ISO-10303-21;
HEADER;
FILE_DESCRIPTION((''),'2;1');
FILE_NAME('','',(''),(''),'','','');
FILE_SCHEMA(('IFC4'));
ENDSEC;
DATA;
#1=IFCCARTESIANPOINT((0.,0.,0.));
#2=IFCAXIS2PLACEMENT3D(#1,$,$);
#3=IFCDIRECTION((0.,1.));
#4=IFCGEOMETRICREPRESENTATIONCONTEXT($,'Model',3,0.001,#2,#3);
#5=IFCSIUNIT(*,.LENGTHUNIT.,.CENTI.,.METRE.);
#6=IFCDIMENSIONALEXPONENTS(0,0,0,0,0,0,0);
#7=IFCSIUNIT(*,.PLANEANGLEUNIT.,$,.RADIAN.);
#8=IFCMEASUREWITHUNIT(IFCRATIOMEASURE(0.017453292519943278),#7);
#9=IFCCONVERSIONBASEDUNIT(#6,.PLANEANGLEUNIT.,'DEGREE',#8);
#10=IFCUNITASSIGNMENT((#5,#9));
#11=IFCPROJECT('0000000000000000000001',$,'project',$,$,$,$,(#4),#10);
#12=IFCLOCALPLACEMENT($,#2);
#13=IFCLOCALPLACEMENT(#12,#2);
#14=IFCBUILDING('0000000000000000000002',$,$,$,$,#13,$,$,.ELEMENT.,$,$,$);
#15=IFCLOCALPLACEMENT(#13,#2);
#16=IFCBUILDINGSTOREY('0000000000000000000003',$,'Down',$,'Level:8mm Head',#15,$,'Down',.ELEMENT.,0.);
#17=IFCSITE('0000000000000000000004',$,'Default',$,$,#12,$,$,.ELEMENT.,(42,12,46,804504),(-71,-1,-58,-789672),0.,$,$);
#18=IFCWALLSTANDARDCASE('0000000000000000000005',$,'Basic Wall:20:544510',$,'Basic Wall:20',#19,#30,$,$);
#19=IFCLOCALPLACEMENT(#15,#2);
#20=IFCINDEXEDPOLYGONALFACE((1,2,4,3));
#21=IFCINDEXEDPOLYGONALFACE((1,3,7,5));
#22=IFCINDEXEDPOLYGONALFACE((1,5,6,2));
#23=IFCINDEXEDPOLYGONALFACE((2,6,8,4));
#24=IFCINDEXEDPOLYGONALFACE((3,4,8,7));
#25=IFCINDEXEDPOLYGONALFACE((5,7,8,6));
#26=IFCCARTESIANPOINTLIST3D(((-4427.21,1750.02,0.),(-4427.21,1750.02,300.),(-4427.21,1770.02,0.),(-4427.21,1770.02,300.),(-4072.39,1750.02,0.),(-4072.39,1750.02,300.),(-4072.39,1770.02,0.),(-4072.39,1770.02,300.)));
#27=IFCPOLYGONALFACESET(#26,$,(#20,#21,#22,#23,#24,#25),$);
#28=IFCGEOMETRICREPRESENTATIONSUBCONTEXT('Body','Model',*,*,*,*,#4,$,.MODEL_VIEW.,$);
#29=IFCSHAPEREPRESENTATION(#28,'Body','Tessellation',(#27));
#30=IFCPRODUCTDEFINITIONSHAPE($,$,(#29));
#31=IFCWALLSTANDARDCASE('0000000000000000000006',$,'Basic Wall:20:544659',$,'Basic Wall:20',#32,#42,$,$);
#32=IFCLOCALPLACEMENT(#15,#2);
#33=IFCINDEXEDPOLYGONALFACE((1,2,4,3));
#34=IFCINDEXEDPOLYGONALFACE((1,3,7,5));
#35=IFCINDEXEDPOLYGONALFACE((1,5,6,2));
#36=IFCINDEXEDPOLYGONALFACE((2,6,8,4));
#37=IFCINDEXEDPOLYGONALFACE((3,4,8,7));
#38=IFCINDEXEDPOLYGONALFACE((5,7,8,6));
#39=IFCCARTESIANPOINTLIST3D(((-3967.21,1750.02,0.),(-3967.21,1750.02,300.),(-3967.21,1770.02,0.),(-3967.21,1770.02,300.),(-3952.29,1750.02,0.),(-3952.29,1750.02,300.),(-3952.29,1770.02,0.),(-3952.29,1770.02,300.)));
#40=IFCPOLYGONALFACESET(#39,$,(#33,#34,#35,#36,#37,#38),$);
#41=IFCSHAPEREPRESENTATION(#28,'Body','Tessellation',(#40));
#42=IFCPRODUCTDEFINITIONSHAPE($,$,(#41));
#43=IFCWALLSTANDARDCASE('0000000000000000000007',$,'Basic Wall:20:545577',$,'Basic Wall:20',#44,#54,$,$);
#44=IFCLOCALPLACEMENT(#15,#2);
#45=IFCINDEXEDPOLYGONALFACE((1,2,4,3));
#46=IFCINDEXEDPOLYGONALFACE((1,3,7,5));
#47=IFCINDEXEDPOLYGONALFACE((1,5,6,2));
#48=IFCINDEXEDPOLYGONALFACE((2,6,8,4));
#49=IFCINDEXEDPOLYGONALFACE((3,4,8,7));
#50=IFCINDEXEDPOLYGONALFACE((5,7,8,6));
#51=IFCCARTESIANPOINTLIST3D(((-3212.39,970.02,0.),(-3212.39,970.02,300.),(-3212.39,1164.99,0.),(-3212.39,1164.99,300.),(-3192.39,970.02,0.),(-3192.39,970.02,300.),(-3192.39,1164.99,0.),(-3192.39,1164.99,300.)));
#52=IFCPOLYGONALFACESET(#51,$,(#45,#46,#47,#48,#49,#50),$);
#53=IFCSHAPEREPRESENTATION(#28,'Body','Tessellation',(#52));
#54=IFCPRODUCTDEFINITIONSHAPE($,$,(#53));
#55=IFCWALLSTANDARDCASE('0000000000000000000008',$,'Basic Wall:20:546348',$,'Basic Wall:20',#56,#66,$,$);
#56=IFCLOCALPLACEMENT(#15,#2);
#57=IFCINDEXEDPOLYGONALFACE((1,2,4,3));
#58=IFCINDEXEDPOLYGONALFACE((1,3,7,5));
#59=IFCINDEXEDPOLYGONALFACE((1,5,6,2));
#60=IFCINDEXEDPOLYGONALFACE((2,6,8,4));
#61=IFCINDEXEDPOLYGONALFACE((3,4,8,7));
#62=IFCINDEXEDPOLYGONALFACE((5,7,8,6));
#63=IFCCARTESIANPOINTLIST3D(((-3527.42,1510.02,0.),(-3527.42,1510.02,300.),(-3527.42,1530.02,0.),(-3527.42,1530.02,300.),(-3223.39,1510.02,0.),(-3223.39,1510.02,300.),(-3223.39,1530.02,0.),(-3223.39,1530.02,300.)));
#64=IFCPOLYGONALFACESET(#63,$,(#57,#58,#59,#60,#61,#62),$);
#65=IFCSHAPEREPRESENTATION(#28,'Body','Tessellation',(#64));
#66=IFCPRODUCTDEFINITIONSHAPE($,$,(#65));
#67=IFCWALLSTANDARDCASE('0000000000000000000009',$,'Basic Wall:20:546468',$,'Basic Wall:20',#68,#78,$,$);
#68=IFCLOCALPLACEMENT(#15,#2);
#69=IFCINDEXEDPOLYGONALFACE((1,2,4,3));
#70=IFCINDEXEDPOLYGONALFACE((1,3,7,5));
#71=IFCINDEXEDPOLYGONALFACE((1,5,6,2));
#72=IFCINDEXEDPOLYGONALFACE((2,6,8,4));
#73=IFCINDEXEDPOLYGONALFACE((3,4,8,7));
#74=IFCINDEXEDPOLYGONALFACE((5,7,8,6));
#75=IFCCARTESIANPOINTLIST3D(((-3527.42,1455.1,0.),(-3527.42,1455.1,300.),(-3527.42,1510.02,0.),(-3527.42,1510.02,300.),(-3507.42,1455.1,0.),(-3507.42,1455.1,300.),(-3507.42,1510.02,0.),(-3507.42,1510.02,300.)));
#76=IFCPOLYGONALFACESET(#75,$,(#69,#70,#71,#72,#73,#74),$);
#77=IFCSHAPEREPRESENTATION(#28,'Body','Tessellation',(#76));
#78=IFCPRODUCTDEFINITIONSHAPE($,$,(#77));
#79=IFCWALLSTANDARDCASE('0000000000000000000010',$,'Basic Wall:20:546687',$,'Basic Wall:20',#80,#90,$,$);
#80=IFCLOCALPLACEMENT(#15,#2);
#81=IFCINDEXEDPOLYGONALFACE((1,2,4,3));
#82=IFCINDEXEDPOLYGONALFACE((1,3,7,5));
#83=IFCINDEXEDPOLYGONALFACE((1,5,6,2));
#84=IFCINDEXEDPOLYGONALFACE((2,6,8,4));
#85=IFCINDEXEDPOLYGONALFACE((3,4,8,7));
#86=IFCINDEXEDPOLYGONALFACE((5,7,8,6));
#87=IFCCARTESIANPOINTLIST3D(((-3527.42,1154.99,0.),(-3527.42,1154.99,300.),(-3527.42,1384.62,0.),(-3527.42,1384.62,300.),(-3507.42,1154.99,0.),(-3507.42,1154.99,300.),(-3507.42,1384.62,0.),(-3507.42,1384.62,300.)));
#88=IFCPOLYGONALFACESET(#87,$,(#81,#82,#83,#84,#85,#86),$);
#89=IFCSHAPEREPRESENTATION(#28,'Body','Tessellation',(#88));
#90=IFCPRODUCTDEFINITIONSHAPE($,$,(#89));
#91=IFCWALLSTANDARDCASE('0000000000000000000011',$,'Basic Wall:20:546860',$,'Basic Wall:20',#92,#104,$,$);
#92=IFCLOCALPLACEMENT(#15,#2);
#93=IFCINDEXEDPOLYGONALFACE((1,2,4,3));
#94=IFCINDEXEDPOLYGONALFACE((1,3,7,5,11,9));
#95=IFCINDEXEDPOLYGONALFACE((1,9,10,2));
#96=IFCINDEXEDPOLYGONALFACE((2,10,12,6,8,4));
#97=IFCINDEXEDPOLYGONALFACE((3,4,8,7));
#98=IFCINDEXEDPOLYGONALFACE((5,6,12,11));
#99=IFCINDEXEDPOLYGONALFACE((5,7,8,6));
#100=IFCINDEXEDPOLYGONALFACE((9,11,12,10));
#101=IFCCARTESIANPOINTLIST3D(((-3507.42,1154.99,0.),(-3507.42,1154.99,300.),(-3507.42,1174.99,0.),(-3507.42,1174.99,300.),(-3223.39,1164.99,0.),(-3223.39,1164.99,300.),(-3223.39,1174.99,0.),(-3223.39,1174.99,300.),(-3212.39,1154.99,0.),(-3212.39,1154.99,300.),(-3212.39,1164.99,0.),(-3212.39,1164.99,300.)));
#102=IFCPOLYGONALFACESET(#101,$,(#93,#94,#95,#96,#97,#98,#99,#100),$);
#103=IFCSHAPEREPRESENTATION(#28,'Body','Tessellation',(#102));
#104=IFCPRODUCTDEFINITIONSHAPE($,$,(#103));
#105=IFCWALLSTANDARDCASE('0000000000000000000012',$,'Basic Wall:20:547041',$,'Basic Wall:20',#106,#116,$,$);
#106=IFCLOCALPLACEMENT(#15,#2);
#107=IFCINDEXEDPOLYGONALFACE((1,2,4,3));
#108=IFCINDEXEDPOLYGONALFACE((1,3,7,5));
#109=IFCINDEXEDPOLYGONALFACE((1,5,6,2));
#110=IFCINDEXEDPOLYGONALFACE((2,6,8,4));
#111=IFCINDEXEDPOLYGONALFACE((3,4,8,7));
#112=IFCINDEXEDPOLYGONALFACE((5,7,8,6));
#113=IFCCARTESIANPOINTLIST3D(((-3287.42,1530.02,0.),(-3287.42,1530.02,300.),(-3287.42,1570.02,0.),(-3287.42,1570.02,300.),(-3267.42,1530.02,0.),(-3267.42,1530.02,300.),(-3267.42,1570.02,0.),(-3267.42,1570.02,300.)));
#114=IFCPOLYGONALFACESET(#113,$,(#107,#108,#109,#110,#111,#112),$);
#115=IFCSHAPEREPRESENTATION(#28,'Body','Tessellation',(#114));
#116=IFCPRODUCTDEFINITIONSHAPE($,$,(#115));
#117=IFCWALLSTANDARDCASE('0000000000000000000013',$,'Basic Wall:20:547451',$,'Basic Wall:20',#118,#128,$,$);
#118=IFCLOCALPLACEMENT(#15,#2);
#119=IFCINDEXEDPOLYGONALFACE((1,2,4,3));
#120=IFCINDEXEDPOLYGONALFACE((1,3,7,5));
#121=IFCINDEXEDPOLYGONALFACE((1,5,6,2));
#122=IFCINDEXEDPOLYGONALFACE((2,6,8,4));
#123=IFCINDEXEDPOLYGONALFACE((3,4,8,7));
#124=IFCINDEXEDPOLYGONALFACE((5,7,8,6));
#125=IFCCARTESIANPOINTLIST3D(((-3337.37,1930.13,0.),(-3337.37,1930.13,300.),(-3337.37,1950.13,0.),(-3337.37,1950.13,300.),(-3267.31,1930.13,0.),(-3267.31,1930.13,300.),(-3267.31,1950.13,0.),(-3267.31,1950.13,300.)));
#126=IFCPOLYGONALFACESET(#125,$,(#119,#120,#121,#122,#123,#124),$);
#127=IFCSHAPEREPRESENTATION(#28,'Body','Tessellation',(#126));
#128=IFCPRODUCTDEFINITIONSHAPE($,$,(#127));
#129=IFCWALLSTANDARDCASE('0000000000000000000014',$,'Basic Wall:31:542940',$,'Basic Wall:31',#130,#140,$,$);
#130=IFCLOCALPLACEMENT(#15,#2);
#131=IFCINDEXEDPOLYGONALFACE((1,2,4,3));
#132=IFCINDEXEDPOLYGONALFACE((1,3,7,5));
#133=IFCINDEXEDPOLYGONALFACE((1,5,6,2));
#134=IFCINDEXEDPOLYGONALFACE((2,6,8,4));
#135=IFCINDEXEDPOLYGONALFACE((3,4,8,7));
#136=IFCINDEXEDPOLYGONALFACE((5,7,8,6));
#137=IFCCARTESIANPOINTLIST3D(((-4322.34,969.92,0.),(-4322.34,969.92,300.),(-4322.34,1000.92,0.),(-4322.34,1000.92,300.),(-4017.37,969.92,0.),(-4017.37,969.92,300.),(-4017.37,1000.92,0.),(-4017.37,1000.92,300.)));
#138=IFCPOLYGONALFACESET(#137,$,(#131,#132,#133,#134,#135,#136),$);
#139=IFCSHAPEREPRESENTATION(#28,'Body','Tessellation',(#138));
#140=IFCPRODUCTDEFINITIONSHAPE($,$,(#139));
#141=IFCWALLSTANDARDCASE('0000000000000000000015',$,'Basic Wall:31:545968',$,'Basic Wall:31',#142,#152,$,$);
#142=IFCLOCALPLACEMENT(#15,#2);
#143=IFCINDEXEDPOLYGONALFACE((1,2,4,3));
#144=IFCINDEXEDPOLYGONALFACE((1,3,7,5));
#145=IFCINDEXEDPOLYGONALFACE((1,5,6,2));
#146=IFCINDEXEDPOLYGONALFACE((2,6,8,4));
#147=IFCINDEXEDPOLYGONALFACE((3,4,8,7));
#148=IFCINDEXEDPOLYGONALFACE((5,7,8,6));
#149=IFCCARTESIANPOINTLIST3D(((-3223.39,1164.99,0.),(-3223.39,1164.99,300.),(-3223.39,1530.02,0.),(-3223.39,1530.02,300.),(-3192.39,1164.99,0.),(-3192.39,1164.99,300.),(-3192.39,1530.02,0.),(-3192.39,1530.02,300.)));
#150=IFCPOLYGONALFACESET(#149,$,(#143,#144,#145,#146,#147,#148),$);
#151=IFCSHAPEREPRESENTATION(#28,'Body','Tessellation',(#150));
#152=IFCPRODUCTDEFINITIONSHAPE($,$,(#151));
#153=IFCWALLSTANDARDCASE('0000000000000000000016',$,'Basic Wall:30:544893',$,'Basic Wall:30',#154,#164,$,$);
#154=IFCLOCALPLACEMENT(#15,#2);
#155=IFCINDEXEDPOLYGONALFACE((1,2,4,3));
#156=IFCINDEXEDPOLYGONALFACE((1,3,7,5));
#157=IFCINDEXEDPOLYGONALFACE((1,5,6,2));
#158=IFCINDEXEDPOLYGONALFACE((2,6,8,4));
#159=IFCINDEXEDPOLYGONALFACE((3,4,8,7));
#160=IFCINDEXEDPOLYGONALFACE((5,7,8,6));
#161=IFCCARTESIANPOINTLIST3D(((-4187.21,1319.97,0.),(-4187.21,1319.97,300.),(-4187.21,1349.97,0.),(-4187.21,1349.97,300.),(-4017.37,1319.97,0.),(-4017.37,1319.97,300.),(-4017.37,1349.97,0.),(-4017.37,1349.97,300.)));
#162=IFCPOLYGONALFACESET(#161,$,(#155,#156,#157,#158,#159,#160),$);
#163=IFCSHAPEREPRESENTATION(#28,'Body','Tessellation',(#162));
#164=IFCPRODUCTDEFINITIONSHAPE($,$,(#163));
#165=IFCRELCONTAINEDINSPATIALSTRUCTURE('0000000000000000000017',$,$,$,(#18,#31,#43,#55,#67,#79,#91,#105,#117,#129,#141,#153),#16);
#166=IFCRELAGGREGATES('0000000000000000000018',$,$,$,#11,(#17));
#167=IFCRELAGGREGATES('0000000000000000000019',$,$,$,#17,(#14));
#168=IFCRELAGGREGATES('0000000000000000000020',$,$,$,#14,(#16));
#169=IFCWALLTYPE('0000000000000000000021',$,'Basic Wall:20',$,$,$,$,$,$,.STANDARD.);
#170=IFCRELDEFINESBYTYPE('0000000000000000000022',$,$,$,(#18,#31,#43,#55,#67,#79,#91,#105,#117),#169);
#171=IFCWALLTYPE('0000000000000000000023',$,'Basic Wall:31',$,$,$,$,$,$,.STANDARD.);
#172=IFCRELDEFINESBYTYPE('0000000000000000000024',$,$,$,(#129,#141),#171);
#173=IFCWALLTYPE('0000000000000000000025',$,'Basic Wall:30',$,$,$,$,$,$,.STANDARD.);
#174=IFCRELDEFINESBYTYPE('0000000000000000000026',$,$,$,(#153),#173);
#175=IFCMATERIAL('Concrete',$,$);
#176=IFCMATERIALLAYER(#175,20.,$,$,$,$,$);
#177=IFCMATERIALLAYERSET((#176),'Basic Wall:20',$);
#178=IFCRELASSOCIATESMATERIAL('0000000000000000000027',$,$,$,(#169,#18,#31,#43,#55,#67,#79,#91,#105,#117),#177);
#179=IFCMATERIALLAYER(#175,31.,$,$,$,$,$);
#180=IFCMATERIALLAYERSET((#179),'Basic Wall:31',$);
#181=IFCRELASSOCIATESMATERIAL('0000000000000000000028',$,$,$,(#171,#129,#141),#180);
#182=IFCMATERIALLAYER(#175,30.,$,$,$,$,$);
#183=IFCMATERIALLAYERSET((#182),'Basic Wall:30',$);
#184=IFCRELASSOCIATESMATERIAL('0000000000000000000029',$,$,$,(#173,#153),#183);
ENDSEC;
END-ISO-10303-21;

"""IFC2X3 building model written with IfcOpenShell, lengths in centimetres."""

from ifc_helpers import new_model, entity, si_unit, converted_unit, direction, frame, frame_2d, origin, place, context, subcontext, project, spatial, polyline, rectangle, outline, extrude, material, layer, layer_set, layer_usage, type_object, element, save


model = new_model("IFC2X3")

# Units and contexts
model_context = context("Model", 3, precision=0.001, world=origin(), true_north=direction((0.0, 1.0)))
body_context = subcontext(model_context, "Body", "Model", "MODEL_VIEW")
ifc_project = project(units=[si_unit("LENGTHUNIT", "METRE", prefix="CENTI"), converted_unit("PLANEANGLEUNIT", "DEGREE", entity("IfcRatioMeasure", 0.017453292519943278), si_unit("PLANEANGLEUNIT", "RADIAN"), dimensions=[0, 0, 0, 0, 0, 0, 0])], contexts=[model_context])

# Site, building, storey
site_placement = place(None, origin())
site = spatial("IfcSite", under=ifc_project, at=site_placement, Name="Default", CompositionType="ELEMENT", RefLatitude=(42, 12, 46, 804504), RefLongitude=(-71, -1, -58, -789672), RefElevation=0.0)
building_placement = place(site_placement, origin())
building = spatial("IfcBuilding", under=site, at=building_placement, CompositionType="ELEMENT")
storey_placement = place(building_placement, origin())
storey = spatial("IfcBuildingStorey", under=building, at=storey_placement, Name="Down", ObjectType="Level:8mm Head", LongName="Down", CompositionType="ELEMENT", Elevation=0.0)

# Shared definitions
ifc_material = material(Name="Concrete")

# Walls
ifc_layer_1 = layer(ifc_material, 20.0)
ifc_layer_set_1 = layer_set([ifc_layer_1], Name="Basic Wall:20")
wall_type_1 = type_object("IfcWallType", Name="Basic Wall:20", PredefinedType="STANDARD", material=ifc_layer_set_1)
ifc_layer_usage_1 = layer_usage(ifc_layer_set_1, "AXIS2", "NEGATIVE", 10.0)
wall_1_placement = place(storey_placement, frame((-4427.21, 1760.02, 0.0)))
element("IfcWallStandardCase", 1, at=wall_1_placement, inside=storey, type_object=wall_type_1, material=ifc_layer_usage_1, Name="Basic Wall:20:544510", ObjectType="Basic Wall:20", context=body_context, shape_type="SweptSolid", body=[
    extrude(rectangle(XDim=354.81, YDim=20.0, at=frame_2d((177.41, 0.0), x_axis=(-1.0, 0.0))), origin(), (0.0, 0.0, 1.0), 300.0),
])
ifc_layer_usage_2 = layer_usage(ifc_layer_set_1, "AXIS2", "NEGATIVE", 10.0)
wall_2_placement = place(storey_placement, frame((-3967.21, 1760.02, 0.0)))
element("IfcWallStandardCase", 2, at=wall_2_placement, inside=storey, type_object=wall_type_1, material=ifc_layer_usage_2, Name="Basic Wall:20:544659", ObjectType="Basic Wall:20", context=body_context, shape_type="SweptSolid", body=[
    extrude(rectangle(XDim=14.92, YDim=20.0, at=frame_2d((7.46, 0.0), x_axis=(-1.0, 0.0))), origin(), (0.0, 0.0, 1.0), 300.0),
])
ifc_layer_usage_3 = layer_usage(ifc_layer_set_1, "AXIS2", "POSITIVE", -10.0)
wall_3_placement = place(storey_placement, frame((-3202.39, 970.02, 0.0), z_axis=(0.0, 0.0, 1.0), x_axis=(0.0, 1.0, 0.0)))
element("IfcWallStandardCase", 3, at=wall_3_placement, inside=storey, type_object=wall_type_1, material=ifc_layer_usage_3, Name="Basic Wall:20:545577", ObjectType="Basic Wall:20", context=body_context, shape_type="SweptSolid", body=[
    extrude(rectangle(XDim=194.97, YDim=20.0, at=frame_2d((97.49, 0.0), x_axis=(-1.0, 0.0))), origin(), (0.0, 0.0, 1.0), 300.0),
])
ifc_layer_usage_4 = layer_usage(ifc_layer_set_1, "AXIS2", "POSITIVE", -10.0)
wall_4_placement = place(storey_placement, frame((-3223.39, 1520.02, 0.0), z_axis=(0.0, 0.0, 1.0), x_axis=(-1.0, 0.0, 0.0)))
element("IfcWallStandardCase", 4, at=wall_4_placement, inside=storey, type_object=wall_type_1, material=ifc_layer_usage_4, Name="Basic Wall:20:546348", ObjectType="Basic Wall:20", context=body_context, shape_type="SweptSolid", body=[
    extrude(rectangle(XDim=304.03, YDim=20.0, at=frame_2d((152.01, 0.0), x_axis=(-1.0, 0.0))), origin(), (0.0, 0.0, 1.0), 300.0),
])
ifc_layer_usage_5 = layer_usage(ifc_layer_set_1, "AXIS2", "POSITIVE", -10.0)
wall_5_placement = place(storey_placement, frame((-3517.42, 1510.02, 0.0), z_axis=(0.0, 0.0, 1.0), x_axis=(0.0, -1.0, 0.0)))
element("IfcWallStandardCase", 5, at=wall_5_placement, inside=storey, type_object=wall_type_1, material=ifc_layer_usage_5, Name="Basic Wall:20:546468", ObjectType="Basic Wall:20", context=body_context, shape_type="SweptSolid", body=[
    extrude(rectangle(XDim=54.92, YDim=20.0, at=frame_2d((27.46, 0.0), x_axis=(-1.0, 0.0))), origin(), (0.0, 0.0, 1.0), 300.0),
])
ifc_layer_usage_6 = layer_usage(ifc_layer_set_1, "AXIS2", "POSITIVE", -10.0)
wall_6_placement = place(storey_placement, frame((-3517.42, 1384.62, 0.0), z_axis=(0.0, 0.0, 1.0), x_axis=(0.0, -1.0, 0.0)))
element("IfcWallStandardCase", 6, at=wall_6_placement, inside=storey, type_object=wall_type_1, material=ifc_layer_usage_6, Name="Basic Wall:20:546687", ObjectType="Basic Wall:20", context=body_context, shape_type="SweptSolid", body=[
    extrude(rectangle(XDim=229.63, YDim=20.0, at=frame_2d((114.81, 0.0), x_axis=(-1.0, 0.0))), origin(), (0.0, 0.0, 1.0), 300.0),
])
ifc_layer_usage_7 = layer_usage(ifc_layer_set_1, "AXIS2", "POSITIVE", -10.0)
wall_7_placement = place(storey_placement, frame((-3507.42, 1164.99, 0.0)))
element("IfcWallStandardCase", 7, at=wall_7_placement, inside=storey, type_object=wall_type_1, material=ifc_layer_usage_7, Name="Basic Wall:20:546860", ObjectType="Basic Wall:20", context=body_context, shape_type="SweptSolid", body=[
    extrude(outline(polyline([(295.03, -10.0), (295.03, 0.0), (284.03, 0.0), (284.03, 10.0), (0.0, 10.0), (0.0, -10.0), (295.03, -10.0)])), origin(), (0.0, 0.0, 1.0), 300.0),
])
ifc_layer_usage_8 = layer_usage(ifc_layer_set_1, "AXIS2", "NEGATIVE", 10.0)
wall_8_placement = place(storey_placement, frame((-3277.42, 1530.02, 0.0), z_axis=(0.0, 0.0, 1.0), x_axis=(0.0, 1.0, 0.0)))
element("IfcWallStandardCase", 8, at=wall_8_placement, inside=storey, type_object=wall_type_1, material=ifc_layer_usage_8, Name="Basic Wall:20:547041", ObjectType="Basic Wall:20", context=body_context, shape_type="SweptSolid", body=[
    extrude(rectangle(XDim=40.0, YDim=20.0, at=frame_2d((20.0, 0.0), x_axis=(-1.0, 0.0))), origin(), (0.0, 0.0, 1.0), 300.0),
])
ifc_layer_usage_9 = layer_usage(ifc_layer_set_1, "AXIS2", "NEGATIVE", 10.0)
wall_9_placement = place(storey_placement, frame((-3337.37, 1940.13, 0.0)))
element("IfcWallStandardCase", 9, at=wall_9_placement, inside=storey, type_object=wall_type_1, material=ifc_layer_usage_9, Name="Basic Wall:20:547451", ObjectType="Basic Wall:20", context=body_context, shape_type="SweptSolid", body=[
    extrude(rectangle(XDim=70.05, YDim=20.0, at=frame_2d((35.03, 0.0), x_axis=(-1.0, 0.0))), origin(), (0.0, 0.0, 1.0), 300.0),
])
ifc_layer_2 = layer(ifc_material, 31.0)
ifc_layer_set_2 = layer_set([ifc_layer_2], Name="Basic Wall:31")
ifc_layer_usage_10 = layer_usage(ifc_layer_set_2, "AXIS2", "POSITIVE", -15.5)
wall_type_2 = type_object("IfcWallType", Name="Basic Wall:31", PredefinedType="STANDARD", material=ifc_layer_set_2)
wall_10_placement = place(storey_placement, frame((-4017.37, 985.42, 0.0), z_axis=(0.0, 0.0, 1.0), x_axis=(-1.0, 0.0, 0.0)))
element("IfcWallStandardCase", 10, at=wall_10_placement, inside=storey, type_object=wall_type_2, material=ifc_layer_usage_10, Name="Basic Wall:31:542940", ObjectType="Basic Wall:31", context=body_context, shape_type="SweptSolid", body=[
    extrude(rectangle(XDim=304.97, YDim=31.0, at=frame_2d((152.49, 0.0), x_axis=(-1.0, 0.0))), origin(), (0.0, 0.0, 1.0), 300.0),
])
ifc_layer_usage_11 = layer_usage(ifc_layer_set_2, "AXIS2", "POSITIVE", -15.5)
wall_11_placement = place(storey_placement, frame((-3207.89, 1164.99, 0.0), z_axis=(0.0, 0.0, 1.0), x_axis=(0.0, 1.0, 0.0)))
element("IfcWallStandardCase", 11, at=wall_11_placement, inside=storey, type_object=wall_type_2, material=ifc_layer_usage_11, Name="Basic Wall:31:545968", ObjectType="Basic Wall:31", context=body_context, shape_type="SweptSolid", body=[
    extrude(rectangle(XDim=365.03, YDim=31.0, at=frame_2d((182.51, 0.0), x_axis=(-1.0, 0.0))), origin(), (0.0, 0.0, 1.0), 300.0),
])
ifc_layer_3 = layer(ifc_material, 30.0)
ifc_layer_set_3 = layer_set([ifc_layer_3], Name="Basic Wall:30")
ifc_layer_usage_12 = layer_usage(ifc_layer_set_3, "AXIS2", "POSITIVE", -15.0)
wall_type_3 = type_object("IfcWallType", Name="Basic Wall:30", PredefinedType="STANDARD", material=ifc_layer_set_3)
wall_12_placement = place(storey_placement, frame((-4187.21, 1334.97, 0.0)))
element("IfcWallStandardCase", 12, at=wall_12_placement, inside=storey, type_object=wall_type_3, material=ifc_layer_usage_12, Name="Basic Wall:30:544893", ObjectType="Basic Wall:30", context=body_context, shape_type="SweptSolid", body=[
    extrude(rectangle(XDim=169.84, YDim=30.0, at=frame_2d((84.92, 0.0), x_axis=(-1.0, 0.0))), origin(), (0.0, 0.0, 1.0), 300.0),
])

save(model, "model.ifc")
